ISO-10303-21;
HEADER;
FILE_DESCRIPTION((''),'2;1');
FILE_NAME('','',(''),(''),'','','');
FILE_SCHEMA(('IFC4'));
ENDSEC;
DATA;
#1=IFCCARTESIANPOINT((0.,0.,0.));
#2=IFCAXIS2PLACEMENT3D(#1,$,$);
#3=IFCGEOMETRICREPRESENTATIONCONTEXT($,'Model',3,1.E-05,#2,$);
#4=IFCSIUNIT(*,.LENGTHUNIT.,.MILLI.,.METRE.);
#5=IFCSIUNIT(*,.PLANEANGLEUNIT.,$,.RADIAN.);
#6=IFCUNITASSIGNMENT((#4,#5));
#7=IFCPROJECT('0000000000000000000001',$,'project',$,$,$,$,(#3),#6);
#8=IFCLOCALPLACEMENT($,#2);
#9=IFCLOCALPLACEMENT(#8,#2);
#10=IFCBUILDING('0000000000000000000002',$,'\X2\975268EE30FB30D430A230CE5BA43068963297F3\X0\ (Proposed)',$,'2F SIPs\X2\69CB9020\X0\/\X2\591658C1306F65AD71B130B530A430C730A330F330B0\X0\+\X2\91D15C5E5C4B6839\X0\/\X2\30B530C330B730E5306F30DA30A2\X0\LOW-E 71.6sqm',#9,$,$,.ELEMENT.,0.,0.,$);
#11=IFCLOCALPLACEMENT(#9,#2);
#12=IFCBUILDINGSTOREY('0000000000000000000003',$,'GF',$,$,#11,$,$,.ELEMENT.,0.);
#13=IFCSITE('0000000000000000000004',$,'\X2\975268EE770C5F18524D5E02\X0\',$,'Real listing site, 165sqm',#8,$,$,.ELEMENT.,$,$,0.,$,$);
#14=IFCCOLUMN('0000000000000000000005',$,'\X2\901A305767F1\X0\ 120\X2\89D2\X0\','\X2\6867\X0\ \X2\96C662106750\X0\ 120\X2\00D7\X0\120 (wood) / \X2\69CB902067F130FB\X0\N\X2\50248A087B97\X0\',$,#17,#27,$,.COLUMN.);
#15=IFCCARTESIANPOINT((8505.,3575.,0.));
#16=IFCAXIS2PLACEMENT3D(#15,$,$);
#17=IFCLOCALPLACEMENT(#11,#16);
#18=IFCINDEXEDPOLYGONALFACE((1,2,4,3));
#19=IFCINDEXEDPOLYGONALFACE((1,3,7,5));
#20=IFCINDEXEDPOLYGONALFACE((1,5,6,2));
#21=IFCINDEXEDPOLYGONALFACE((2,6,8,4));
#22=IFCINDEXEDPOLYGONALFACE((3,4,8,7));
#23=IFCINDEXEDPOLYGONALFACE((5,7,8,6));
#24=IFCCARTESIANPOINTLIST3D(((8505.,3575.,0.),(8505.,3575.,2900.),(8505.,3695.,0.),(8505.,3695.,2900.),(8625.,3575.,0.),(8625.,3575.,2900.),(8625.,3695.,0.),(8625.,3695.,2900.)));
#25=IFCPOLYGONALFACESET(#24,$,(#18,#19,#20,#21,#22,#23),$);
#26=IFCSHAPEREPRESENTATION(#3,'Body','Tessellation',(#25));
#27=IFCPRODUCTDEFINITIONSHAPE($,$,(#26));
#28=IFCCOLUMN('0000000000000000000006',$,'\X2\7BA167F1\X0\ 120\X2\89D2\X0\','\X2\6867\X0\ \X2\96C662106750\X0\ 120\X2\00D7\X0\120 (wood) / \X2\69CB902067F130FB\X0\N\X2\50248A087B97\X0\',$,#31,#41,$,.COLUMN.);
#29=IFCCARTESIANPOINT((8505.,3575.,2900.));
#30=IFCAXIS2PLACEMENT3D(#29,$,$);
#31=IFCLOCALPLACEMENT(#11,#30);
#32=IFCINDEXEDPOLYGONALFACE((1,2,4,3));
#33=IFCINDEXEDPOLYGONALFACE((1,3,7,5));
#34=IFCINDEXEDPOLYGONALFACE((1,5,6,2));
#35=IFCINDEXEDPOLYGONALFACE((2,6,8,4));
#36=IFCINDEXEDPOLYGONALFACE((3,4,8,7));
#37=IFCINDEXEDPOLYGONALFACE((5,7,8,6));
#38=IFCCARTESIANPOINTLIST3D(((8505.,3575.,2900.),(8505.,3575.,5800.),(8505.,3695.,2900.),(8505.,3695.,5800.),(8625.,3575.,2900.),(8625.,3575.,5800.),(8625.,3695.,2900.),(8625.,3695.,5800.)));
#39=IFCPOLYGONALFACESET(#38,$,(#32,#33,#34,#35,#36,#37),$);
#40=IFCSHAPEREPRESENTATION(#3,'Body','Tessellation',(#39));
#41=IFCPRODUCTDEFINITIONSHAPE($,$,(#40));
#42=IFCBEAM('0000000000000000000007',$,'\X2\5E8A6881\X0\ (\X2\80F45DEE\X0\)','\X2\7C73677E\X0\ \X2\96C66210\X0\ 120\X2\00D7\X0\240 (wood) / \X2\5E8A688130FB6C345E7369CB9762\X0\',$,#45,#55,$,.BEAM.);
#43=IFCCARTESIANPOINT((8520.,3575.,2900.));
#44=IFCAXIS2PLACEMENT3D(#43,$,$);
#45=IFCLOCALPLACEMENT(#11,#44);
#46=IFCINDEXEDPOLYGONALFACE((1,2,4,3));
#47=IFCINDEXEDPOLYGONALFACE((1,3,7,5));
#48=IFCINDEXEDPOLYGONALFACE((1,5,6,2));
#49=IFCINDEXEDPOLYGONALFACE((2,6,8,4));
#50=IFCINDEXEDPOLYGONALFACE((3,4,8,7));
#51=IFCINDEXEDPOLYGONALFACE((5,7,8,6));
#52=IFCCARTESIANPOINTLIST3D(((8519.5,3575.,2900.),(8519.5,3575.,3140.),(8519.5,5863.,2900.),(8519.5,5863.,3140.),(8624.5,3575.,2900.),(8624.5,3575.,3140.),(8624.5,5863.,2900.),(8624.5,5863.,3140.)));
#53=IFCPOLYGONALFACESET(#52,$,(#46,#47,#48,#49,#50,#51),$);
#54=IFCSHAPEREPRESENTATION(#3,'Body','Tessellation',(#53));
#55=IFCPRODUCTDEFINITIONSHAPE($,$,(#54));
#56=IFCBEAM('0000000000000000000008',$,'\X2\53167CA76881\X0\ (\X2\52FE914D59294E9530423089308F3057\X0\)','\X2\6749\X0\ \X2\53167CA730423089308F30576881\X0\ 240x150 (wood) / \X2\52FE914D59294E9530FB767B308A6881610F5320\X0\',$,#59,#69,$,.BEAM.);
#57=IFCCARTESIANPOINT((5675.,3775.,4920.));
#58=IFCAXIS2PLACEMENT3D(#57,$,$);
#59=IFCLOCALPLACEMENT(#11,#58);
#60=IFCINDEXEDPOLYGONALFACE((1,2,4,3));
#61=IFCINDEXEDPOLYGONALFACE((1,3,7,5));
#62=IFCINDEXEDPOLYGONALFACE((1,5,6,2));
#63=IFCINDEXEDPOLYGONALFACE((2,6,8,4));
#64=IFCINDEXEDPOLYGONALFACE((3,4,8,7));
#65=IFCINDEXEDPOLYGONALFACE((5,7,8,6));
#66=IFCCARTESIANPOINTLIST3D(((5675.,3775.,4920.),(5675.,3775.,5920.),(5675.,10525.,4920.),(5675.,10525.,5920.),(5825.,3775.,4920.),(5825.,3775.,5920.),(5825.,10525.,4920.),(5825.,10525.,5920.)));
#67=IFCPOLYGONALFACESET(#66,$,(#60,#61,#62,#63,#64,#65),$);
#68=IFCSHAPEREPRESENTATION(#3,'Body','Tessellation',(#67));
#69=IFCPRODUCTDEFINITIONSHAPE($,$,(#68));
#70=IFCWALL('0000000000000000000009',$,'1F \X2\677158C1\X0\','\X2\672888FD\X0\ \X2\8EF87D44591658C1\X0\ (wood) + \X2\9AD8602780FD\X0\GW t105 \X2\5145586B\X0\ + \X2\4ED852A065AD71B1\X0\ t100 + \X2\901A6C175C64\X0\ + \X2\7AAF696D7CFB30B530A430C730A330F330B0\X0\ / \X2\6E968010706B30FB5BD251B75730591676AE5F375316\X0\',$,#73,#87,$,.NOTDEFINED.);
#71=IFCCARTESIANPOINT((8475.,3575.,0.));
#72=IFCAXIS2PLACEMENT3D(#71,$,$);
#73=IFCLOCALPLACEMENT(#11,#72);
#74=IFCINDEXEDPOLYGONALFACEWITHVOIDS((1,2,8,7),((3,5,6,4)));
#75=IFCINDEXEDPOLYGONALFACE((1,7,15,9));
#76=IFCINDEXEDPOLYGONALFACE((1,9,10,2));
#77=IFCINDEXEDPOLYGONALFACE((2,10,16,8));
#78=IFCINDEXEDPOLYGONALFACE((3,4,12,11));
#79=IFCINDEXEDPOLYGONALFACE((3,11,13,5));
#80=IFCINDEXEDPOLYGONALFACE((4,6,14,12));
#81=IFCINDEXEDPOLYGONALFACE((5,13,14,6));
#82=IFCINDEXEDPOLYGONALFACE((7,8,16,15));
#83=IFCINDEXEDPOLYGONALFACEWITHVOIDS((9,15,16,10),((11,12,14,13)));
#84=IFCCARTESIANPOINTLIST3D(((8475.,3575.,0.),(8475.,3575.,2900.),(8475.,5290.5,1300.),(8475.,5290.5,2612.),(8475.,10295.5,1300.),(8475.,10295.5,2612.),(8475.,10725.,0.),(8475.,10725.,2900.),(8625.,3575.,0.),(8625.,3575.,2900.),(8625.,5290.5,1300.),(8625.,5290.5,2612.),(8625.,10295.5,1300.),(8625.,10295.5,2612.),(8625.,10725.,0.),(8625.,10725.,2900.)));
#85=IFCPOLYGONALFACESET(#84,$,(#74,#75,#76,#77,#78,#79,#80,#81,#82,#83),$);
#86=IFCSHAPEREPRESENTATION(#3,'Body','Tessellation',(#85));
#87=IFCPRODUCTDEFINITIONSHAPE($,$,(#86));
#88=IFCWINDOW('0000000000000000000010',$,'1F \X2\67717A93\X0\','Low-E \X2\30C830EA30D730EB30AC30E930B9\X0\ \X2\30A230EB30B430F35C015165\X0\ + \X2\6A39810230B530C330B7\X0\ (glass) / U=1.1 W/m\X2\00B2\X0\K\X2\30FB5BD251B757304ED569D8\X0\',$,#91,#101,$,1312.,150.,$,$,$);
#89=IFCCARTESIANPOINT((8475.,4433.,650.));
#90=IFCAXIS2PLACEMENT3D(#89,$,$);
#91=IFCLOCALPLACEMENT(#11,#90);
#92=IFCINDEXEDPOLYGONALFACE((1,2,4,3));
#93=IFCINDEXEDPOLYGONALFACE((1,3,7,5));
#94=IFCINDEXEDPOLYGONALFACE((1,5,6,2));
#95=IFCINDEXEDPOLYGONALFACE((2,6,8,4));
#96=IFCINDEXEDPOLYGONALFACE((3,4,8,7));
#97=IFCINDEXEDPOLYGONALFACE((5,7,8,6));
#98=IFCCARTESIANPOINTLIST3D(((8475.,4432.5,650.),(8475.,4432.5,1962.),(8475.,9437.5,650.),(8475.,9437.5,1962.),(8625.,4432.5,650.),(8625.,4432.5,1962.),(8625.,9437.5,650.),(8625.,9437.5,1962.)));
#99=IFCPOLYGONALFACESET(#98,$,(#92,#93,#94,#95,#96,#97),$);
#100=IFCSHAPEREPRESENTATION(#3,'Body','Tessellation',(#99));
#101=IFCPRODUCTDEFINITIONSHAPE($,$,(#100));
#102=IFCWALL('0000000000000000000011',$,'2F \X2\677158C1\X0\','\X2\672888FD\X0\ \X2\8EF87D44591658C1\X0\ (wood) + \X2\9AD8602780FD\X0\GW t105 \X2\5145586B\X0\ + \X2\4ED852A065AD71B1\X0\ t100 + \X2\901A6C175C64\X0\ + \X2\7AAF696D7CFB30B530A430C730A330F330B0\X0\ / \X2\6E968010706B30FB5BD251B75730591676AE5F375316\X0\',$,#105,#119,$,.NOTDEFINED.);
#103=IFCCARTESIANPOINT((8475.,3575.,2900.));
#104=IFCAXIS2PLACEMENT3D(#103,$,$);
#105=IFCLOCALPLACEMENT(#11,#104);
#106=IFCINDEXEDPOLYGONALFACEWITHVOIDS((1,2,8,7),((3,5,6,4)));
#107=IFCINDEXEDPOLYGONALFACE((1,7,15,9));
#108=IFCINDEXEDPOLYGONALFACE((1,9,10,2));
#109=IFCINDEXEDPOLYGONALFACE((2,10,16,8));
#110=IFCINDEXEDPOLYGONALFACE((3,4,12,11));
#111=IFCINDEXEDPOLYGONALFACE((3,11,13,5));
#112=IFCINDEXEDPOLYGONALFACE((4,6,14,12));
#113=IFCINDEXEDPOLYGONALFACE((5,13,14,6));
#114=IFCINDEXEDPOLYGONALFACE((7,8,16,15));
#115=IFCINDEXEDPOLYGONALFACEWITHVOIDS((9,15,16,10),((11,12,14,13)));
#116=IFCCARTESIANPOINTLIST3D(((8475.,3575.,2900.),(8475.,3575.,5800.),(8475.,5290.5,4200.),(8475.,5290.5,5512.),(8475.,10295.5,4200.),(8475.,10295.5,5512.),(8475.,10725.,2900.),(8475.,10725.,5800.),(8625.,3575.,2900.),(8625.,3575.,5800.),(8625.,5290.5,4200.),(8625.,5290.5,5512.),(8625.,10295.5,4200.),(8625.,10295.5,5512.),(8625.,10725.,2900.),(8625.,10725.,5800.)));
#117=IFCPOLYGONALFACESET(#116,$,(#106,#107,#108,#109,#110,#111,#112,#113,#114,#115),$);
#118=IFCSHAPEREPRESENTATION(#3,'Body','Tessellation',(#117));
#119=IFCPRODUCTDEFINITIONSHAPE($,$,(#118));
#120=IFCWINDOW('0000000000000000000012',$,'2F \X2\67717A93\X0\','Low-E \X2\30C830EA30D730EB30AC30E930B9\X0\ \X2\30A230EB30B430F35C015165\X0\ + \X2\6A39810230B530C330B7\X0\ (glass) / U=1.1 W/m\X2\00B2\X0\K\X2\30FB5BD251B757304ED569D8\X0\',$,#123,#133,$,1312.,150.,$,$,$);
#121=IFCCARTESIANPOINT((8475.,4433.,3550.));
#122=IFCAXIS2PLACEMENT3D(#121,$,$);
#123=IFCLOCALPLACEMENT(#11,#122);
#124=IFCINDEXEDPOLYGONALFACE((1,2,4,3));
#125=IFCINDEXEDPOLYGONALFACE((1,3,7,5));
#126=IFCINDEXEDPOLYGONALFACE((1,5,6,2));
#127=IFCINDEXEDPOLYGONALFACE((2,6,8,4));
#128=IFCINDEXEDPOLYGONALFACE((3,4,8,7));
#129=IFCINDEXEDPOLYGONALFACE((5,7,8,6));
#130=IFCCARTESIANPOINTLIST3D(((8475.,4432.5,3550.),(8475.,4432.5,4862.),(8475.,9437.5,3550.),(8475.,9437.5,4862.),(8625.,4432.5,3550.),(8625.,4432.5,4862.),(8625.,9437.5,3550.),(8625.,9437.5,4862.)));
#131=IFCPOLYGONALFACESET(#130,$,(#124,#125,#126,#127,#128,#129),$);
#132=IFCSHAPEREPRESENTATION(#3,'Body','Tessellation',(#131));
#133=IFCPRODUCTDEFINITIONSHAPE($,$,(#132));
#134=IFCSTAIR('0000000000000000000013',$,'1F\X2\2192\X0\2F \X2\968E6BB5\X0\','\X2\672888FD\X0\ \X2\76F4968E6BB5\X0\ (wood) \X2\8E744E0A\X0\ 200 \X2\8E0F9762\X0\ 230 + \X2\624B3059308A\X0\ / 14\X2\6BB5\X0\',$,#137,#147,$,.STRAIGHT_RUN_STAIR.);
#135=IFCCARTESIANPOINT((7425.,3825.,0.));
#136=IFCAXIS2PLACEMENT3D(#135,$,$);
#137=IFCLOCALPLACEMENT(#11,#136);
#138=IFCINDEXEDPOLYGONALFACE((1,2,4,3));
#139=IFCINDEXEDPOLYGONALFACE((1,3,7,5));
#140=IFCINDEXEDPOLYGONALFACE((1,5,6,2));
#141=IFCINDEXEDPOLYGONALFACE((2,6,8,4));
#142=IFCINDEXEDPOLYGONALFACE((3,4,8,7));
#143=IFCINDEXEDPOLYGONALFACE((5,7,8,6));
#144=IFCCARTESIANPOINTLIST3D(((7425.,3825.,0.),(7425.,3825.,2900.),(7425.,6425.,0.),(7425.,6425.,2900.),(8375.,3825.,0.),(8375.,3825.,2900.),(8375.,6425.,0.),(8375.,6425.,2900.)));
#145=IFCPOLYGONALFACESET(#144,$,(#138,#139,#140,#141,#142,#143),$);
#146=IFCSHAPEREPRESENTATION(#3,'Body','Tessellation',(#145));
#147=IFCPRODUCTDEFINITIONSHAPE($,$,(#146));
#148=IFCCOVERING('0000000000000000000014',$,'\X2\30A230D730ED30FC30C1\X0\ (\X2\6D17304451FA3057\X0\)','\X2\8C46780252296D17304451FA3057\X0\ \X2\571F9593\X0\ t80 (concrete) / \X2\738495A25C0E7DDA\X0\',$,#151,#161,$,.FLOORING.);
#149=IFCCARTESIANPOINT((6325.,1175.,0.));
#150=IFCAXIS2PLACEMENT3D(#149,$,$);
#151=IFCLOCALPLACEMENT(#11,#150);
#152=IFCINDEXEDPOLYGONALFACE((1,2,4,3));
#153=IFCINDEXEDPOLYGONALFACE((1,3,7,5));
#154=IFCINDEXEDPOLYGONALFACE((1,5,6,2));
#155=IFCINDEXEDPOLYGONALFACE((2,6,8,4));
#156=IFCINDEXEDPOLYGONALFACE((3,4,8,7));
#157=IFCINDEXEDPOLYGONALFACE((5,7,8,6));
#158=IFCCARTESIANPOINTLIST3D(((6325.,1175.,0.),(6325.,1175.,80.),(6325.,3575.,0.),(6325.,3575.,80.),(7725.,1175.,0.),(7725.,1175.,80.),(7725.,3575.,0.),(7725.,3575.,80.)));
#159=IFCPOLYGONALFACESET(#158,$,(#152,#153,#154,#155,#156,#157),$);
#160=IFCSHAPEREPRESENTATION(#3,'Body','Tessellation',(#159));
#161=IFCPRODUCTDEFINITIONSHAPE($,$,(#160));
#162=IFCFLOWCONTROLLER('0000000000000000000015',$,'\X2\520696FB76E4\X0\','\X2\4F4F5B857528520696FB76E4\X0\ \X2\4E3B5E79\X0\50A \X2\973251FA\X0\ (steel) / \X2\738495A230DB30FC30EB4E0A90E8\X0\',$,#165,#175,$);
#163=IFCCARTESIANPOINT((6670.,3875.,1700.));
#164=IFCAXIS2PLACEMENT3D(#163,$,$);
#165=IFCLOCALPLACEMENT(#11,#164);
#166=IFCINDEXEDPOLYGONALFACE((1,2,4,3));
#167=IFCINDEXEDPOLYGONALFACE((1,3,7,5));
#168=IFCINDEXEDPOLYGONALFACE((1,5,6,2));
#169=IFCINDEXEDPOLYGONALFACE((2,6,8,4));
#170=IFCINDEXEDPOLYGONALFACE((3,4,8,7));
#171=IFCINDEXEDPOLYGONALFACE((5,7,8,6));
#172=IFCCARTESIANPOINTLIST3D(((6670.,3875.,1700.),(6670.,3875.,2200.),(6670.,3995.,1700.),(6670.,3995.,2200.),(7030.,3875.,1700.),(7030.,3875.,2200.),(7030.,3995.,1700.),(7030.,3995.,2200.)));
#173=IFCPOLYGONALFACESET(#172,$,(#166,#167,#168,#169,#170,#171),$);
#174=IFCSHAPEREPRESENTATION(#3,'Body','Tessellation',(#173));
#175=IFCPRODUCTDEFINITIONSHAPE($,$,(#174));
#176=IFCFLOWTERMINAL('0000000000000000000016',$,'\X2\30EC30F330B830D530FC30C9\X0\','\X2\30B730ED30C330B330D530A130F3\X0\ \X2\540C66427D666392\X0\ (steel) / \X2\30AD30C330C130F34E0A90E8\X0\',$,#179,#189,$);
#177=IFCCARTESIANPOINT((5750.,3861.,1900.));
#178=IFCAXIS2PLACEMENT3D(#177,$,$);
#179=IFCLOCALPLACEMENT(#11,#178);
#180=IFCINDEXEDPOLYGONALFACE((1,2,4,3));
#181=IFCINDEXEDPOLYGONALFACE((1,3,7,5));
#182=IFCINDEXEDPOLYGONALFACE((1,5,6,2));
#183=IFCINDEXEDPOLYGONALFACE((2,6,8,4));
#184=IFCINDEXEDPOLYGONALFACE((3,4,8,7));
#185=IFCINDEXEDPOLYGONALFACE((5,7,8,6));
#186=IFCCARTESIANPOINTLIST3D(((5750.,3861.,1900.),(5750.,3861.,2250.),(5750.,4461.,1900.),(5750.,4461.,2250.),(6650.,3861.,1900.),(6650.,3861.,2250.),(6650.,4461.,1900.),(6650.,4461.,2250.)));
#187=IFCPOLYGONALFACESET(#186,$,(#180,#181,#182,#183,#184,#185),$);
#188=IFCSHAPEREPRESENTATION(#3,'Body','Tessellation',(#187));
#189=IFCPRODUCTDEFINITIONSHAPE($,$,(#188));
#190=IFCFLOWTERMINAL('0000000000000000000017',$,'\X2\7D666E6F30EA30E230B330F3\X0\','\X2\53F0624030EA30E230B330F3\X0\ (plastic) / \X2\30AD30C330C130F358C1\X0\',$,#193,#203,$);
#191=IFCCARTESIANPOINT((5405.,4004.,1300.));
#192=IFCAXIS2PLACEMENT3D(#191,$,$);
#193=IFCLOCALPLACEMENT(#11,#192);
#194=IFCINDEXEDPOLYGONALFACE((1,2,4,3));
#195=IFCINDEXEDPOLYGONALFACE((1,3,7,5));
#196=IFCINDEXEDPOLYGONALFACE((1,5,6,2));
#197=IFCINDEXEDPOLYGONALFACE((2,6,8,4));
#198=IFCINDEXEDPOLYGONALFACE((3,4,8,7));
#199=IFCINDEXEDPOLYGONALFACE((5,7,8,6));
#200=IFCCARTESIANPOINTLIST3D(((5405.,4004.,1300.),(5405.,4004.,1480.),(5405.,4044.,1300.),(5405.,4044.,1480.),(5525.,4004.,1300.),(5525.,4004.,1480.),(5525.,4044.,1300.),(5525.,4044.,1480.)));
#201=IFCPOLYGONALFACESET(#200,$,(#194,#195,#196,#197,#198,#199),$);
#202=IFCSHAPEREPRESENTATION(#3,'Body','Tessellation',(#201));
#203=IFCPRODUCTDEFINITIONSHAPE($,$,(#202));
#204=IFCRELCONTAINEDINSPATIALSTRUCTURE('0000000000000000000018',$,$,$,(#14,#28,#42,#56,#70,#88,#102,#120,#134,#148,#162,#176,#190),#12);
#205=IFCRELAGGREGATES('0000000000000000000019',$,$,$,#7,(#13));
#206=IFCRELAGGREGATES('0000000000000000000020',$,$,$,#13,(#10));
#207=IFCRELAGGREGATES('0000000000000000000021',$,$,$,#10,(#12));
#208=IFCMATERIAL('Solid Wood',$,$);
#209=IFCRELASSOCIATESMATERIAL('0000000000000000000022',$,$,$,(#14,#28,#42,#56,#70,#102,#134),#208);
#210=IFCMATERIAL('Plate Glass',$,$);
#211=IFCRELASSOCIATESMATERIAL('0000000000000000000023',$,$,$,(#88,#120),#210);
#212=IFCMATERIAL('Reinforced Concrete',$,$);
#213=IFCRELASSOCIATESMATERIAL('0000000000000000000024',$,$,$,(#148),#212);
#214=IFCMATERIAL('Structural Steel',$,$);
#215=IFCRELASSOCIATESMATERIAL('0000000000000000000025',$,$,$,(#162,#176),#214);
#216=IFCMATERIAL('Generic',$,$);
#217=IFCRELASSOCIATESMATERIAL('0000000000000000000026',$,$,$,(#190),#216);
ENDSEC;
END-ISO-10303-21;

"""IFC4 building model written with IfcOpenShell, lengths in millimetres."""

from ifc_helpers import new_model, si_unit, frame, frame_2d, origin, place, context, project, spatial, rectangle, extrude, material, element, fill, save


model = new_model("IFC4")

# Units and contexts
model_context = context("Model", 3, precision=1e-05, world=origin())
ifc_project = project(units=[si_unit("LENGTHUNIT", "METRE", prefix="MILLI"), si_unit("PLANEANGLEUNIT", "RADIAN")], contexts=[model_context])

# Site, building, storey
site_placement = place(None, origin())
site = spatial("IfcSite", under=ifc_project, at=site_placement, Name="青森県弘前市", ObjectType="Real listing site, 165sqm", CompositionType="ELEMENT", RefElevation=0.0)
building_placement = place(site_placement, origin())
building = spatial("IfcBuilding", under=site, at=building_placement, Name="青森・ピアノ室と防音 (Proposed)", ObjectType="2F SIPs構造/外壁は断熱サイディング+金属屋根/サッシュはペアLOW-E 71.6sqm", CompositionType="ELEMENT", ElevationOfRefHeight=0.0, ElevationOfTerrain=0.0)
storey_placement = place(building_placement, origin())
storey = spatial("IfcBuildingStorey", under=building, at=storey_placement, Name="GF", CompositionType="ELEMENT", Elevation=0.0)

# Columns
ifc_material_1 = material(Name="Solid Wood")
column_1_placement = place(storey_placement, frame((8505.0, 3575.0, 0.0)))
element("IfcColumn", 1, at=column_1_placement, inside=storey, material=ifc_material_1, Name="通し柱 120角", Description="桧 集成材 120×120 (wood) / 構造柱・N値計算", PredefinedType="COLUMN", context=model_context, shape_type="SweptSolid", body=[
    extrude(rectangle(XDim=120.0, YDim=120.0, at=frame_2d((60.0, 60.0))), frame((8505.0, 3575.0, 0.0)), (0.0, 0.0, 1.0), 2900.0),
])
column_2_placement = place(storey_placement, frame((8505.0, 3575.0, 2900.0)))
element("IfcColumn", 2, at=column_2_placement, inside=storey, material=ifc_material_1, Name="管柱 120角", Description="桧 集成材 120×120 (wood) / 構造柱・N値計算", PredefinedType="COLUMN", context=model_context, shape_type="SweptSolid", body=[
    extrude(rectangle(XDim=120.0, YDim=120.0, at=frame_2d((60.0, 60.0))), frame((8505.0, 3575.0, 2900.0)), (0.0, 0.0, 1.0), 2900.0),
])

# Beams
beam_1_placement = place(storey_placement, frame((8520.0, 3575.0, 2900.0)))
element("IfcBeam", 3, at=beam_1_placement, inside=storey, material=ifc_material_1, Name="床梁 (胴差)", Description="米松 集成 120×240 (wood) / 床梁・水平構面", PredefinedType="BEAM", context=model_context, shape_type="SweptSolid", body=[
    extrude(rectangle(XDim=105.0, YDim=2288.0, at=frame_2d((52.0, 1144.0))), frame((8520.0, 3575.0, 2900.0)), (0.0, 0.0, 1.0), 240.0),
])
beam_2_placement = place(storey_placement, frame((5675.0, 3775.0, 4920.0)))
element("IfcBeam", 4, at=beam_2_placement, inside=storey, material=ifc_material_1, Name="化粧梁 (勾配天井あらわし)", Description="杉 化粧あらわし梁 240x150 (wood) / 勾配天井・登り梁意匠", PredefinedType="BEAM", context=model_context, shape_type="SweptSolid", body=[
    extrude(rectangle(XDim=150.0, YDim=6750.0, at=frame_2d((75.0, 3375.0))), frame((5675.0, 3775.0, 4920.0)), (0.0, 0.0, 1.0), 1000.0),
])

# Wall, opening, window
wall_1_placement = place(storey_placement, frame((8475.0, 3575.0, 0.0)))
wall_1 = element("IfcWall", 5, at=wall_1_placement, inside=storey, material=ifc_material_1, Name="1F 東壁", Description="木製 軸組外壁 (wood) + 高性能GW t105 充填 + 付加断熱 t100 + 通気層 + 窯業系サイディング / 準耐火・寒冷地外皮強化", PredefinedType="NOTDEFINED", context=model_context, shape_type="SweptSolid", body=[
    extrude(rectangle(XDim=150.0, YDim=7150.0, at=frame_2d((75.0, 3575.0))), frame((8475.0, 3575.0, 0.0)), (0.0, 0.0, 1.0), 2900.0),
])
opening_1_placement = place(storey_placement, frame((8475.0, 4433.0, 650.0)))
opening_1 = element("IfcOpeningElement", 6, at=opening_1_placement, cuts=wall_1, PredefinedType="NOTDEFINED", context=model_context, shape_type="SweptSolid", body=[
    extrude(rectangle(XDim=150.0, YDim=5005.0, at=frame_2d((75.0, 2502.0))), frame((8475.0, 4433.0, 650.0)), (0.0, 0.0, 1.0), 1312.0),
])
ifc_material_2 = material(Name="Plate Glass")
window_1_placement = place(storey_placement, frame((8475.0, 4433.0, 650.0)))
window_1 = element("IfcWindow", 7, at=window_1_placement, inside=storey, material=ifc_material_2, Name="1F 東窓", Description="Low-E トリプルガラス アルゴン封入 + 樹脂サッシ (glass) / U=1.1 W/m²K・寒冷地仕様", OverallHeight=1312.0, OverallWidth=150.0, context=model_context, shape_type="SweptSolid", body=[
    extrude(rectangle(XDim=150.0, YDim=5005.0, at=frame_2d((75.0, 2502.0))), frame((8475.0, 4433.0, 650.0)), (0.0, 0.0, 1.0), 1312.0),
])
fill(opening_1, window_1)

# Wall, opening, window
wall_2_placement = place(storey_placement, frame((8475.0, 3575.0, 2900.0)))
wall_2 = element("IfcWall", 8, at=wall_2_placement, inside=storey, material=ifc_material_1, Name="2F 東壁", Description="木製 軸組外壁 (wood) + 高性能GW t105 充填 + 付加断熱 t100 + 通気層 + 窯業系サイディング / 準耐火・寒冷地外皮強化", PredefinedType="NOTDEFINED", context=model_context, shape_type="SweptSolid", body=[
    extrude(rectangle(XDim=150.0, YDim=7150.0, at=frame_2d((75.0, 3575.0))), frame((8475.0, 3575.0, 2900.0)), (0.0, 0.0, 1.0), 2900.0),
])
opening_2_placement = place(storey_placement, frame((8475.0, 4433.0, 3550.0)))
opening_2 = element("IfcOpeningElement", 9, at=opening_2_placement, cuts=wall_2, PredefinedType="NOTDEFINED", context=model_context, shape_type="SweptSolid", body=[
    extrude(rectangle(XDim=150.0, YDim=5005.0, at=frame_2d((75.0, 2502.0))), frame((8475.0, 4433.0, 3550.0)), (0.0, 0.0, 1.0), 1312.0),
])
window_2_placement = place(storey_placement, frame((8475.0, 4433.0, 3550.0)))
window_2 = element("IfcWindow", 10, at=window_2_placement, inside=storey, material=ifc_material_2, Name="2F 東窓", Description="Low-E トリプルガラス アルゴン封入 + 樹脂サッシ (glass) / U=1.1 W/m²K・寒冷地仕様", OverallHeight=1312.0, OverallWidth=150.0, context=model_context, shape_type="SweptSolid", body=[
    extrude(rectangle(XDim=150.0, YDim=5005.0, at=frame_2d((75.0, 2502.0))), frame((8475.0, 4433.0, 3550.0)), (0.0, 0.0, 1.0), 1312.0),
])
fill(opening_2, window_2)

# Stair
stair_placement = place(storey_placement, frame((7425.0, 3825.0, 0.0)))
element("IfcStair", 11, at=stair_placement, inside=storey, material=ifc_material_1, Name="1F→2F 階段", Description="木製 直階段 (wood) 蹴上 200 踏面 230 + 手すり / 14段", PredefinedType="STRAIGHT_RUN_STAIR", context=model_context, shape_type="SweptSolid", body=[
    extrude(rectangle(XDim=950.0, YDim=2600.0, at=frame_2d((475.0, 1300.0))), frame((7425.0, 3825.0, 0.0)), (0.0, 0.0, 1.0), 2900.0),
])

# Covering
ifc_material_3 = material(Name="Reinforced Concrete")
covering_placement = place(storey_placement, frame((6325.0, 1175.0, 0.0)))
element("IfcCovering", 12, at=covering_placement, inside=storey, material=ifc_material_3, Name="アプローチ (洗い出し)", Description="豆砂利洗い出し 土間 t80 (concrete) / 玄関導線", PredefinedType="FLOORING", context=model_context, shape_type="SweptSolid", body=[
    extrude(rectangle(XDim=1400.0, YDim=2400.0, at=frame_2d((700.0, 1200.0))), frame((6325.0, 1175.0, 0.0)), (0.0, 0.0, 1.0), 80.0),
])

# Flow controller
ifc_material_4 = material(Name="Structural Steel")
flow_controller_placement = place(storey_placement, frame((6670.0, 3875.0, 1700.0)))
element("IfcFlowController", 13, at=flow_controller_placement, inside=storey, material=ifc_material_4, Name="分電盤", Description="住宅用分電盤 主幹50A 露出 (steel) / 玄関ホール上部", context=model_context, shape_type="SweptSolid", body=[
    extrude(rectangle(XDim=360.0, YDim=120.0, at=frame_2d((180.0, 60.0))), frame((6670.0, 3875.0, 1700.0)), (0.0, 0.0, 1.0), 500.0),
])

# Flow terminals
flow_terminal_1_placement = place(storey_placement, frame((5750.0, 3861.0, 1900.0)))
element("IfcFlowTerminal", 14, at=flow_terminal_1_placement, inside=storey, material=ifc_material_4, Name="レンジフード", Description="シロッコファン 同時給排 (steel) / キッチン上部", context=model_context, shape_type="SweptSolid", body=[
    extrude(rectangle(XDim=900.0, YDim=600.0, at=frame_2d((450.0, 300.0))), frame((5750.0, 3861.0, 1900.0)), (0.0, 0.0, 1.0), 350.0),
])
ifc_material_5 = material(Name="Generic")
flow_terminal_2_placement = place(storey_placement, frame((5405.0, 4004.0, 1300.0)))
element("IfcFlowTerminal", 15, at=flow_terminal_2_placement, inside=storey, material=ifc_material_5, Name="給湯リモコン", Description="台所リモコン (plastic) / キッチン壁", context=model_context, shape_type="SweptSolid", body=[
    extrude(rectangle(XDim=120.0, YDim=40.0, at=frame_2d((60.0, 20.0))), frame((5405.0, 4004.0, 1300.0)), (0.0, 0.0, 1.0), 180.0),
])

save(model, "model.ifc")
